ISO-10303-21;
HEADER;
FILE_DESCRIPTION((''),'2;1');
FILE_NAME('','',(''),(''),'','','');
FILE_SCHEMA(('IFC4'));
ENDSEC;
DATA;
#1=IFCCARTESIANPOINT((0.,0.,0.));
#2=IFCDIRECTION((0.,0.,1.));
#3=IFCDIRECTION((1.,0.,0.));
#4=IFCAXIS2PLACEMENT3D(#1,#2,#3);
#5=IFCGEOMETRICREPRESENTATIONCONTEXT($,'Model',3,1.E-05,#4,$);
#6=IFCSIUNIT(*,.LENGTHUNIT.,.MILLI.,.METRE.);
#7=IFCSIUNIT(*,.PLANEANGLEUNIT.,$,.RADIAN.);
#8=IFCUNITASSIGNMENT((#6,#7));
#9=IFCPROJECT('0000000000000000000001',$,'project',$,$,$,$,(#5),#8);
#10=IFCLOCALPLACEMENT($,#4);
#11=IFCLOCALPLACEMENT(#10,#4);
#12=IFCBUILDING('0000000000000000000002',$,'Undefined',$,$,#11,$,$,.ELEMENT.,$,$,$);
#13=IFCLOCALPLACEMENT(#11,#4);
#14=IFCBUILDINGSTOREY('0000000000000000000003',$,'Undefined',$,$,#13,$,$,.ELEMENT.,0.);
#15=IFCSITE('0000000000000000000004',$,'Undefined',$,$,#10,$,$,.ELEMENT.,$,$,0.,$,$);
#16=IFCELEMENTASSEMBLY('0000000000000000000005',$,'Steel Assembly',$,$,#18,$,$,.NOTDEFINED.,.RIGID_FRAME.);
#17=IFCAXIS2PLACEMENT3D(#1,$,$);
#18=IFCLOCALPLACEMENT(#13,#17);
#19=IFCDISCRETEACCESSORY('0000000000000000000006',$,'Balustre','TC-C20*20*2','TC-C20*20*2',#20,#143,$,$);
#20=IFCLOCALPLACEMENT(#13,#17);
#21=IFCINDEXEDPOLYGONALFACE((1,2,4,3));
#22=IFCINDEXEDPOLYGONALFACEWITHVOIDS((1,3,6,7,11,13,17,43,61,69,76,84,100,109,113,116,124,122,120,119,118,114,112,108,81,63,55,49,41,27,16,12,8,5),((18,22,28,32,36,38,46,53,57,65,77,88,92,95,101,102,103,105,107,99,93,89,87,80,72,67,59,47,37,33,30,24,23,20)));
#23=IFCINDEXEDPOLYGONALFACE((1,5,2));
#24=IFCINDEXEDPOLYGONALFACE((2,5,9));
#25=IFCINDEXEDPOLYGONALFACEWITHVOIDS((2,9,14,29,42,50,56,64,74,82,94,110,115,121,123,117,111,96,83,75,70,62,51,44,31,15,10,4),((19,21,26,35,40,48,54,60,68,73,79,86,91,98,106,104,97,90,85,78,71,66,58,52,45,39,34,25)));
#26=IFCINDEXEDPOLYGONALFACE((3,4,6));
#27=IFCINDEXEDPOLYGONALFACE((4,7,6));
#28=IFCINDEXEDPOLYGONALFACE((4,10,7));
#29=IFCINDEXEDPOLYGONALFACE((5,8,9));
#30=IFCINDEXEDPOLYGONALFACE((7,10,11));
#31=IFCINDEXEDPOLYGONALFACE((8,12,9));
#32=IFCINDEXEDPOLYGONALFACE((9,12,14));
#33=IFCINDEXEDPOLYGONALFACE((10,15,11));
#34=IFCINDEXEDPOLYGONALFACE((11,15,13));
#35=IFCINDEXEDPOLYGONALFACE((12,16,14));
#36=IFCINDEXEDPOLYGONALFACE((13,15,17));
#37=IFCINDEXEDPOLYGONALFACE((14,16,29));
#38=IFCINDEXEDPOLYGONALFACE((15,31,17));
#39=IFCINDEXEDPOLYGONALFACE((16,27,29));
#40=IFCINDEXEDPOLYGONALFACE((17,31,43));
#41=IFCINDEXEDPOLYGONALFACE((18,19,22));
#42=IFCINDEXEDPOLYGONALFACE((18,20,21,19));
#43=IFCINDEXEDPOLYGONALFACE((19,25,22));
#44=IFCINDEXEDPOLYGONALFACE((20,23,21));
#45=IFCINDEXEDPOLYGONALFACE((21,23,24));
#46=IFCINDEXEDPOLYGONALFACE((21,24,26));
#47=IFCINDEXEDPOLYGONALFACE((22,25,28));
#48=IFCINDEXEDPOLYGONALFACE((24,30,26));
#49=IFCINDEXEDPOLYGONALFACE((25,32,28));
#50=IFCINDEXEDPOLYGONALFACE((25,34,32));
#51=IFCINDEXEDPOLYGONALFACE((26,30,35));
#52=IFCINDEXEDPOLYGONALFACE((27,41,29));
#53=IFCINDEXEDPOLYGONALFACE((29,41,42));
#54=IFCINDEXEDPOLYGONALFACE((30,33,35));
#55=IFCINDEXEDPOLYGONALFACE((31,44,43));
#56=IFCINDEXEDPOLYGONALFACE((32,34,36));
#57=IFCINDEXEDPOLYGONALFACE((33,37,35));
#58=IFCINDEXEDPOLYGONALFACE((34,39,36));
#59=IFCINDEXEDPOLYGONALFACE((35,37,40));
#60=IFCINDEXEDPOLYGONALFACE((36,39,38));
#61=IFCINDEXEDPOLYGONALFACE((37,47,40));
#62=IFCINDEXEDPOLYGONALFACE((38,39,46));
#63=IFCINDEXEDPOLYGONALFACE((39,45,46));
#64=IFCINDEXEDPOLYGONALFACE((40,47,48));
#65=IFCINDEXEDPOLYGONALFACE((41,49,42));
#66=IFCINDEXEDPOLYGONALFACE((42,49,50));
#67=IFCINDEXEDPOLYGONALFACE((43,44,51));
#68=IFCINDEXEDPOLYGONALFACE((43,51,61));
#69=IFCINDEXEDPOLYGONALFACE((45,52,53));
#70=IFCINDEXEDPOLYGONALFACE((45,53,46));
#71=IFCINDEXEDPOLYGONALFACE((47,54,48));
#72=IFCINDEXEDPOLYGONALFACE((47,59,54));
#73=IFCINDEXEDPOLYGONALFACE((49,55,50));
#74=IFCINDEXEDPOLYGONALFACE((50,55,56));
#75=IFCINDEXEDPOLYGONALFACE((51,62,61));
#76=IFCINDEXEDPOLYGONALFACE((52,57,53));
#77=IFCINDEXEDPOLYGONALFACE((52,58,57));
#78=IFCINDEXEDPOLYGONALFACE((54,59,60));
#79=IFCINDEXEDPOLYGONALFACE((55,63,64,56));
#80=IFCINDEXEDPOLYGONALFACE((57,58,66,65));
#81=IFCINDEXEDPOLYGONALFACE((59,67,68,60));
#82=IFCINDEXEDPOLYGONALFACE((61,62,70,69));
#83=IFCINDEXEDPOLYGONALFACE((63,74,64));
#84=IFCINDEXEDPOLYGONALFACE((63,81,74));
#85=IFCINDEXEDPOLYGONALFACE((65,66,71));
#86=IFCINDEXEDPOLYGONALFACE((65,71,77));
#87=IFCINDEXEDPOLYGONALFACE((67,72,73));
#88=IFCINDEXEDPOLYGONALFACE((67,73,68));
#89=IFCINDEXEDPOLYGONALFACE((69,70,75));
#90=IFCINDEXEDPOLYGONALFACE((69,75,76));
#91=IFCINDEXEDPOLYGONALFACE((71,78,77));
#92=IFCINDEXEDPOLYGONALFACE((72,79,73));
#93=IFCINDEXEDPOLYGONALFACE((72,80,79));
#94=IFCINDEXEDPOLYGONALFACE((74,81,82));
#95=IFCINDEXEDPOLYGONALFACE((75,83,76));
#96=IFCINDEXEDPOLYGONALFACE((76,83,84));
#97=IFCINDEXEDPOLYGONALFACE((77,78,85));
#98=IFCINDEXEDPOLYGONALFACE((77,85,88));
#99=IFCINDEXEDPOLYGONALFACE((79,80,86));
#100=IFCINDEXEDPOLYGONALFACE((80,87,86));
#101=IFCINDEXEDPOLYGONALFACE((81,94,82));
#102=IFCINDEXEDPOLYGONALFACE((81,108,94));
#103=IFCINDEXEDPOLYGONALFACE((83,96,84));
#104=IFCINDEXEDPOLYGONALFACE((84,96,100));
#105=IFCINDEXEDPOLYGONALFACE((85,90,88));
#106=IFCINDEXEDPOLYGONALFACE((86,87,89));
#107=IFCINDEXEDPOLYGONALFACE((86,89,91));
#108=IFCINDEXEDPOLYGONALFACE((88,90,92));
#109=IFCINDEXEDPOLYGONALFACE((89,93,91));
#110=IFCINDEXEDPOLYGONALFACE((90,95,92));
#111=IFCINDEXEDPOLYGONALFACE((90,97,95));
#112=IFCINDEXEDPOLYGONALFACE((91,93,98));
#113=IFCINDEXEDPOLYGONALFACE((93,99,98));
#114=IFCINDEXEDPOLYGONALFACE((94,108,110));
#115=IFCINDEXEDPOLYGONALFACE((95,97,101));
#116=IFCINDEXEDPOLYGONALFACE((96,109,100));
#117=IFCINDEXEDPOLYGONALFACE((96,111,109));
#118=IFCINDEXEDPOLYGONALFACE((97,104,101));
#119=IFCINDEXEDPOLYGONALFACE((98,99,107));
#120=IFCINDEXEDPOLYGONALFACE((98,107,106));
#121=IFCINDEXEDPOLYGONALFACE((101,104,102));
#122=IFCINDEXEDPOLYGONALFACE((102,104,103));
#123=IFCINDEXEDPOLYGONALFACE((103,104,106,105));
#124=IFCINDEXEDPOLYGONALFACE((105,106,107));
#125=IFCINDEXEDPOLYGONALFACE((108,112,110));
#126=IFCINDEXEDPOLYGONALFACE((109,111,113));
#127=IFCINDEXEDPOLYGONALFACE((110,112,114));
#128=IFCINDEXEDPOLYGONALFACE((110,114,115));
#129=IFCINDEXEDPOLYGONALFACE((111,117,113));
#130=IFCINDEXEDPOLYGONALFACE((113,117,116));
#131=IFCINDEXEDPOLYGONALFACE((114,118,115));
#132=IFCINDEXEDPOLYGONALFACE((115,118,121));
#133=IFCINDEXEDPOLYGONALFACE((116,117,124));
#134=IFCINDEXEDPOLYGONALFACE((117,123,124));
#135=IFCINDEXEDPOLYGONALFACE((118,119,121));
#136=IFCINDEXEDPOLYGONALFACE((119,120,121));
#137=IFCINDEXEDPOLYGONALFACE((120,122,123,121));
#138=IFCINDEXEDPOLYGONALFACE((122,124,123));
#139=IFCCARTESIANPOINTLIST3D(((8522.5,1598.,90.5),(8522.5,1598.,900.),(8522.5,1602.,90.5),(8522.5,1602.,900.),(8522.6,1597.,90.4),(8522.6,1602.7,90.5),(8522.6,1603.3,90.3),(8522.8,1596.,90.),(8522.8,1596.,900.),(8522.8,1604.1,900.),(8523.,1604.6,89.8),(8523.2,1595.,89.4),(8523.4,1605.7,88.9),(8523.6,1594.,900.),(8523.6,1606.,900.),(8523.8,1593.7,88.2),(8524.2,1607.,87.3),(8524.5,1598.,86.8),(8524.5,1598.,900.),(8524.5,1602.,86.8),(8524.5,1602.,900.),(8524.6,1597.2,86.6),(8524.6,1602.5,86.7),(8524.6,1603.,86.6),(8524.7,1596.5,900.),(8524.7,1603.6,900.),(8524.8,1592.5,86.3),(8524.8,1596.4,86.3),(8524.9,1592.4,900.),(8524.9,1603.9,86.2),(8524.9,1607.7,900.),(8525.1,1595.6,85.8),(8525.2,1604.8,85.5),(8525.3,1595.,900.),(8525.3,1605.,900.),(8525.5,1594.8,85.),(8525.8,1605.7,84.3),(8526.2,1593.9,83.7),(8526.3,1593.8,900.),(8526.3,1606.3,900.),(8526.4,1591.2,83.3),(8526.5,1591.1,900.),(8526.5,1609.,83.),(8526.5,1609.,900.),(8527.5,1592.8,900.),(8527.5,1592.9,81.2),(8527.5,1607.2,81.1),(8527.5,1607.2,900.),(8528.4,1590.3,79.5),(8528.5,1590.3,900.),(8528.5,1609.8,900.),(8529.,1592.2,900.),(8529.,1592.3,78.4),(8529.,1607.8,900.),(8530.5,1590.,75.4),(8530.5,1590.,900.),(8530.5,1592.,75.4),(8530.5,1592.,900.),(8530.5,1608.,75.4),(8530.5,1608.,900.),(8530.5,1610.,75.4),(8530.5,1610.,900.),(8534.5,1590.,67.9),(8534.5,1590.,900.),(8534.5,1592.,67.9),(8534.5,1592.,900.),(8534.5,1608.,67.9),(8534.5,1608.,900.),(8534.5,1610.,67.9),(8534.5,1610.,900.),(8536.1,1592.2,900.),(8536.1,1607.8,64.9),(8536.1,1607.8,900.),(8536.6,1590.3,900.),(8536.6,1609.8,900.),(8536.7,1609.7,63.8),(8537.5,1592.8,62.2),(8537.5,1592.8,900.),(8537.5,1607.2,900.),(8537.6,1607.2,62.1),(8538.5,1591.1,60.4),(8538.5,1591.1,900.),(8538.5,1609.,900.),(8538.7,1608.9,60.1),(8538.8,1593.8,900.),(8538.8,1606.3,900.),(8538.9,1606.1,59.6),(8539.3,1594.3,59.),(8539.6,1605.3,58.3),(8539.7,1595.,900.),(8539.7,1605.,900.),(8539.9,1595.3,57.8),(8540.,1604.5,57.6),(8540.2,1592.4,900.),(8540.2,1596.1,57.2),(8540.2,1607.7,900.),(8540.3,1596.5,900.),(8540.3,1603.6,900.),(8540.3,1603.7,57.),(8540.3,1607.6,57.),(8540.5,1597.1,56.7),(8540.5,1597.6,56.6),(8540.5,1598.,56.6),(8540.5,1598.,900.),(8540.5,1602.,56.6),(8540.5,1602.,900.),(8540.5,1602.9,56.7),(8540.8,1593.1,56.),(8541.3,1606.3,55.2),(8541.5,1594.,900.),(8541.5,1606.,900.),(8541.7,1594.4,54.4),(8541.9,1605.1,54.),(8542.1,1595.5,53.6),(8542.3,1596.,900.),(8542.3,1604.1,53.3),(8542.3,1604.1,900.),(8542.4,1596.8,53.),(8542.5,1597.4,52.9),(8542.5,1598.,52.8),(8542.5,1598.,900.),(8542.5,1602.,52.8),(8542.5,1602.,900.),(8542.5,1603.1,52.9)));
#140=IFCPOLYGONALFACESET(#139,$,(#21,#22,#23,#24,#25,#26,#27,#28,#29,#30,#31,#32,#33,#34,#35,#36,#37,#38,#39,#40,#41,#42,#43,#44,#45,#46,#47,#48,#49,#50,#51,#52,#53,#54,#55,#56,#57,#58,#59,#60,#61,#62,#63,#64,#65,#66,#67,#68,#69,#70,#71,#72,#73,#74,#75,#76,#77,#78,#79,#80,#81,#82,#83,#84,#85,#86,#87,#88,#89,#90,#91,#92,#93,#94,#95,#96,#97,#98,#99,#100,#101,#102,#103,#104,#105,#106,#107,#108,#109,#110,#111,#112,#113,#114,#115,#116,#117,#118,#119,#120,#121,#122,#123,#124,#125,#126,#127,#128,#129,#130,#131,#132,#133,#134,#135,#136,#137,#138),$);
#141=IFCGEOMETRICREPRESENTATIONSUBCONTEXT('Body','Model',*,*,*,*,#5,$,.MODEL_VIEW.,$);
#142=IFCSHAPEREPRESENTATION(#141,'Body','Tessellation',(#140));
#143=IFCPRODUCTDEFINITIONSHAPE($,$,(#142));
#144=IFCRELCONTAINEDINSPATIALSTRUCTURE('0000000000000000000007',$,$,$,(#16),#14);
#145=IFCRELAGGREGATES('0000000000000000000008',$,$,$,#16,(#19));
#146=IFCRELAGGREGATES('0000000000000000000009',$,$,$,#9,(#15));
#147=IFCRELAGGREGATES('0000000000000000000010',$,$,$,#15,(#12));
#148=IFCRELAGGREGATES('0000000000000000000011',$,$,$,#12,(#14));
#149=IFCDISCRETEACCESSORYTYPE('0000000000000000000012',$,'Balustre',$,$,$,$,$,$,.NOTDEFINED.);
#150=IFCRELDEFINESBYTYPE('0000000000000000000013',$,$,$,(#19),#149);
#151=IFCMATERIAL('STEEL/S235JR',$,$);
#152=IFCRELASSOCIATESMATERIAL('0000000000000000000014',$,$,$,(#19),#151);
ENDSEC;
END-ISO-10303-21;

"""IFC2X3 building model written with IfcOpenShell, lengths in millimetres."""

from ifc_helpers import new_model, si_unit, frame, origin_with_axes, origin_2d_with_axis, place, context, subcontext, project, spatial, hollow_rectangle, extrude, clip, halfspace, material, type_object, element, aggregate, save


model = new_model("IFC2X3")

# Units and contexts
model_context = context("Model", 3, precision=1e-05, world=origin_with_axes())
body_context = subcontext(model_context, "Body", "Model", "MODEL_VIEW")
ifc_project = project(units=[si_unit("LENGTHUNIT", "METRE", prefix="MILLI"), si_unit("PLANEANGLEUNIT", "RADIAN")], contexts=[model_context])

# Site, building, storey
site_placement = place(None, origin_with_axes())
site = spatial("IfcSite", under=ifc_project, at=site_placement, Name="Undefined", CompositionType="ELEMENT", RefElevation=0.0)
building_placement = place(site_placement, origin_with_axes())
building = spatial("IfcBuilding", under=site, at=building_placement, Name="Undefined", CompositionType="ELEMENT")
storey_placement = place(building_placement, origin_with_axes())
storey = spatial("IfcBuildingStorey", under=building, at=storey_placement, Name="Undefined", CompositionType="ELEMENT", Elevation=0.0)

# Shared definitions
ifc_material = material(Name="STEEL/S235JR")

# Element assembly, discrete accessory
discrete_accessory_type_1 = type_object("IfcDiscreteAccessoryType", Name="Balustre")
assembly_1_placement = place(storey_placement, origin_with_axes())
assembly_1 = element("IfcElementAssembly", 1, at=assembly_1_placement, inside=storey, Name="Steel Assembly", AssemblyPlace="NOTDEFINED", PredefinedType="RIGID_FRAME")
discrete_accessory_1_placement = place(assembly_1_placement, frame((8532.5, 1600.0, 900.0), z_axis=(0.0, 1.0, 0.0), x_axis=(0.0, 0.0, -1.0)))
discrete_accessory_1 = element("IfcDiscreteAccessory", 2, at=discrete_accessory_1_placement, type_object=discrete_accessory_type_1, material=ifc_material, Name="Balustre", Description="TC-C20*20*2", ObjectType="TC-C20*20*2", context=body_context, shape_type="Clipping", body=[
    clip(extrude(hollow_rectangle(XDim=20.0, YDim=20.0, WallThickness=2.0, InnerFilletRadius=6.0, OuterFilletRadius=8.0, at=origin_2d_with_axis()), frame((847.4, 0.0, 0.0), z_axis=(-1.0, 0.0, 0.0), x_axis=(0.0, -1.0, 0.0)), (0.0, 0.0, 1.0), 847.4), halfspace(frame((285.4, 287.9, 0.0), z_axis=(-0.46842, -0.883506, 0.000005), x_axis=(0.0, 0.000005, 1.0)), True)),
])

aggregate(assembly_1, [discrete_accessory_1])

save(model, "model.ifc")
